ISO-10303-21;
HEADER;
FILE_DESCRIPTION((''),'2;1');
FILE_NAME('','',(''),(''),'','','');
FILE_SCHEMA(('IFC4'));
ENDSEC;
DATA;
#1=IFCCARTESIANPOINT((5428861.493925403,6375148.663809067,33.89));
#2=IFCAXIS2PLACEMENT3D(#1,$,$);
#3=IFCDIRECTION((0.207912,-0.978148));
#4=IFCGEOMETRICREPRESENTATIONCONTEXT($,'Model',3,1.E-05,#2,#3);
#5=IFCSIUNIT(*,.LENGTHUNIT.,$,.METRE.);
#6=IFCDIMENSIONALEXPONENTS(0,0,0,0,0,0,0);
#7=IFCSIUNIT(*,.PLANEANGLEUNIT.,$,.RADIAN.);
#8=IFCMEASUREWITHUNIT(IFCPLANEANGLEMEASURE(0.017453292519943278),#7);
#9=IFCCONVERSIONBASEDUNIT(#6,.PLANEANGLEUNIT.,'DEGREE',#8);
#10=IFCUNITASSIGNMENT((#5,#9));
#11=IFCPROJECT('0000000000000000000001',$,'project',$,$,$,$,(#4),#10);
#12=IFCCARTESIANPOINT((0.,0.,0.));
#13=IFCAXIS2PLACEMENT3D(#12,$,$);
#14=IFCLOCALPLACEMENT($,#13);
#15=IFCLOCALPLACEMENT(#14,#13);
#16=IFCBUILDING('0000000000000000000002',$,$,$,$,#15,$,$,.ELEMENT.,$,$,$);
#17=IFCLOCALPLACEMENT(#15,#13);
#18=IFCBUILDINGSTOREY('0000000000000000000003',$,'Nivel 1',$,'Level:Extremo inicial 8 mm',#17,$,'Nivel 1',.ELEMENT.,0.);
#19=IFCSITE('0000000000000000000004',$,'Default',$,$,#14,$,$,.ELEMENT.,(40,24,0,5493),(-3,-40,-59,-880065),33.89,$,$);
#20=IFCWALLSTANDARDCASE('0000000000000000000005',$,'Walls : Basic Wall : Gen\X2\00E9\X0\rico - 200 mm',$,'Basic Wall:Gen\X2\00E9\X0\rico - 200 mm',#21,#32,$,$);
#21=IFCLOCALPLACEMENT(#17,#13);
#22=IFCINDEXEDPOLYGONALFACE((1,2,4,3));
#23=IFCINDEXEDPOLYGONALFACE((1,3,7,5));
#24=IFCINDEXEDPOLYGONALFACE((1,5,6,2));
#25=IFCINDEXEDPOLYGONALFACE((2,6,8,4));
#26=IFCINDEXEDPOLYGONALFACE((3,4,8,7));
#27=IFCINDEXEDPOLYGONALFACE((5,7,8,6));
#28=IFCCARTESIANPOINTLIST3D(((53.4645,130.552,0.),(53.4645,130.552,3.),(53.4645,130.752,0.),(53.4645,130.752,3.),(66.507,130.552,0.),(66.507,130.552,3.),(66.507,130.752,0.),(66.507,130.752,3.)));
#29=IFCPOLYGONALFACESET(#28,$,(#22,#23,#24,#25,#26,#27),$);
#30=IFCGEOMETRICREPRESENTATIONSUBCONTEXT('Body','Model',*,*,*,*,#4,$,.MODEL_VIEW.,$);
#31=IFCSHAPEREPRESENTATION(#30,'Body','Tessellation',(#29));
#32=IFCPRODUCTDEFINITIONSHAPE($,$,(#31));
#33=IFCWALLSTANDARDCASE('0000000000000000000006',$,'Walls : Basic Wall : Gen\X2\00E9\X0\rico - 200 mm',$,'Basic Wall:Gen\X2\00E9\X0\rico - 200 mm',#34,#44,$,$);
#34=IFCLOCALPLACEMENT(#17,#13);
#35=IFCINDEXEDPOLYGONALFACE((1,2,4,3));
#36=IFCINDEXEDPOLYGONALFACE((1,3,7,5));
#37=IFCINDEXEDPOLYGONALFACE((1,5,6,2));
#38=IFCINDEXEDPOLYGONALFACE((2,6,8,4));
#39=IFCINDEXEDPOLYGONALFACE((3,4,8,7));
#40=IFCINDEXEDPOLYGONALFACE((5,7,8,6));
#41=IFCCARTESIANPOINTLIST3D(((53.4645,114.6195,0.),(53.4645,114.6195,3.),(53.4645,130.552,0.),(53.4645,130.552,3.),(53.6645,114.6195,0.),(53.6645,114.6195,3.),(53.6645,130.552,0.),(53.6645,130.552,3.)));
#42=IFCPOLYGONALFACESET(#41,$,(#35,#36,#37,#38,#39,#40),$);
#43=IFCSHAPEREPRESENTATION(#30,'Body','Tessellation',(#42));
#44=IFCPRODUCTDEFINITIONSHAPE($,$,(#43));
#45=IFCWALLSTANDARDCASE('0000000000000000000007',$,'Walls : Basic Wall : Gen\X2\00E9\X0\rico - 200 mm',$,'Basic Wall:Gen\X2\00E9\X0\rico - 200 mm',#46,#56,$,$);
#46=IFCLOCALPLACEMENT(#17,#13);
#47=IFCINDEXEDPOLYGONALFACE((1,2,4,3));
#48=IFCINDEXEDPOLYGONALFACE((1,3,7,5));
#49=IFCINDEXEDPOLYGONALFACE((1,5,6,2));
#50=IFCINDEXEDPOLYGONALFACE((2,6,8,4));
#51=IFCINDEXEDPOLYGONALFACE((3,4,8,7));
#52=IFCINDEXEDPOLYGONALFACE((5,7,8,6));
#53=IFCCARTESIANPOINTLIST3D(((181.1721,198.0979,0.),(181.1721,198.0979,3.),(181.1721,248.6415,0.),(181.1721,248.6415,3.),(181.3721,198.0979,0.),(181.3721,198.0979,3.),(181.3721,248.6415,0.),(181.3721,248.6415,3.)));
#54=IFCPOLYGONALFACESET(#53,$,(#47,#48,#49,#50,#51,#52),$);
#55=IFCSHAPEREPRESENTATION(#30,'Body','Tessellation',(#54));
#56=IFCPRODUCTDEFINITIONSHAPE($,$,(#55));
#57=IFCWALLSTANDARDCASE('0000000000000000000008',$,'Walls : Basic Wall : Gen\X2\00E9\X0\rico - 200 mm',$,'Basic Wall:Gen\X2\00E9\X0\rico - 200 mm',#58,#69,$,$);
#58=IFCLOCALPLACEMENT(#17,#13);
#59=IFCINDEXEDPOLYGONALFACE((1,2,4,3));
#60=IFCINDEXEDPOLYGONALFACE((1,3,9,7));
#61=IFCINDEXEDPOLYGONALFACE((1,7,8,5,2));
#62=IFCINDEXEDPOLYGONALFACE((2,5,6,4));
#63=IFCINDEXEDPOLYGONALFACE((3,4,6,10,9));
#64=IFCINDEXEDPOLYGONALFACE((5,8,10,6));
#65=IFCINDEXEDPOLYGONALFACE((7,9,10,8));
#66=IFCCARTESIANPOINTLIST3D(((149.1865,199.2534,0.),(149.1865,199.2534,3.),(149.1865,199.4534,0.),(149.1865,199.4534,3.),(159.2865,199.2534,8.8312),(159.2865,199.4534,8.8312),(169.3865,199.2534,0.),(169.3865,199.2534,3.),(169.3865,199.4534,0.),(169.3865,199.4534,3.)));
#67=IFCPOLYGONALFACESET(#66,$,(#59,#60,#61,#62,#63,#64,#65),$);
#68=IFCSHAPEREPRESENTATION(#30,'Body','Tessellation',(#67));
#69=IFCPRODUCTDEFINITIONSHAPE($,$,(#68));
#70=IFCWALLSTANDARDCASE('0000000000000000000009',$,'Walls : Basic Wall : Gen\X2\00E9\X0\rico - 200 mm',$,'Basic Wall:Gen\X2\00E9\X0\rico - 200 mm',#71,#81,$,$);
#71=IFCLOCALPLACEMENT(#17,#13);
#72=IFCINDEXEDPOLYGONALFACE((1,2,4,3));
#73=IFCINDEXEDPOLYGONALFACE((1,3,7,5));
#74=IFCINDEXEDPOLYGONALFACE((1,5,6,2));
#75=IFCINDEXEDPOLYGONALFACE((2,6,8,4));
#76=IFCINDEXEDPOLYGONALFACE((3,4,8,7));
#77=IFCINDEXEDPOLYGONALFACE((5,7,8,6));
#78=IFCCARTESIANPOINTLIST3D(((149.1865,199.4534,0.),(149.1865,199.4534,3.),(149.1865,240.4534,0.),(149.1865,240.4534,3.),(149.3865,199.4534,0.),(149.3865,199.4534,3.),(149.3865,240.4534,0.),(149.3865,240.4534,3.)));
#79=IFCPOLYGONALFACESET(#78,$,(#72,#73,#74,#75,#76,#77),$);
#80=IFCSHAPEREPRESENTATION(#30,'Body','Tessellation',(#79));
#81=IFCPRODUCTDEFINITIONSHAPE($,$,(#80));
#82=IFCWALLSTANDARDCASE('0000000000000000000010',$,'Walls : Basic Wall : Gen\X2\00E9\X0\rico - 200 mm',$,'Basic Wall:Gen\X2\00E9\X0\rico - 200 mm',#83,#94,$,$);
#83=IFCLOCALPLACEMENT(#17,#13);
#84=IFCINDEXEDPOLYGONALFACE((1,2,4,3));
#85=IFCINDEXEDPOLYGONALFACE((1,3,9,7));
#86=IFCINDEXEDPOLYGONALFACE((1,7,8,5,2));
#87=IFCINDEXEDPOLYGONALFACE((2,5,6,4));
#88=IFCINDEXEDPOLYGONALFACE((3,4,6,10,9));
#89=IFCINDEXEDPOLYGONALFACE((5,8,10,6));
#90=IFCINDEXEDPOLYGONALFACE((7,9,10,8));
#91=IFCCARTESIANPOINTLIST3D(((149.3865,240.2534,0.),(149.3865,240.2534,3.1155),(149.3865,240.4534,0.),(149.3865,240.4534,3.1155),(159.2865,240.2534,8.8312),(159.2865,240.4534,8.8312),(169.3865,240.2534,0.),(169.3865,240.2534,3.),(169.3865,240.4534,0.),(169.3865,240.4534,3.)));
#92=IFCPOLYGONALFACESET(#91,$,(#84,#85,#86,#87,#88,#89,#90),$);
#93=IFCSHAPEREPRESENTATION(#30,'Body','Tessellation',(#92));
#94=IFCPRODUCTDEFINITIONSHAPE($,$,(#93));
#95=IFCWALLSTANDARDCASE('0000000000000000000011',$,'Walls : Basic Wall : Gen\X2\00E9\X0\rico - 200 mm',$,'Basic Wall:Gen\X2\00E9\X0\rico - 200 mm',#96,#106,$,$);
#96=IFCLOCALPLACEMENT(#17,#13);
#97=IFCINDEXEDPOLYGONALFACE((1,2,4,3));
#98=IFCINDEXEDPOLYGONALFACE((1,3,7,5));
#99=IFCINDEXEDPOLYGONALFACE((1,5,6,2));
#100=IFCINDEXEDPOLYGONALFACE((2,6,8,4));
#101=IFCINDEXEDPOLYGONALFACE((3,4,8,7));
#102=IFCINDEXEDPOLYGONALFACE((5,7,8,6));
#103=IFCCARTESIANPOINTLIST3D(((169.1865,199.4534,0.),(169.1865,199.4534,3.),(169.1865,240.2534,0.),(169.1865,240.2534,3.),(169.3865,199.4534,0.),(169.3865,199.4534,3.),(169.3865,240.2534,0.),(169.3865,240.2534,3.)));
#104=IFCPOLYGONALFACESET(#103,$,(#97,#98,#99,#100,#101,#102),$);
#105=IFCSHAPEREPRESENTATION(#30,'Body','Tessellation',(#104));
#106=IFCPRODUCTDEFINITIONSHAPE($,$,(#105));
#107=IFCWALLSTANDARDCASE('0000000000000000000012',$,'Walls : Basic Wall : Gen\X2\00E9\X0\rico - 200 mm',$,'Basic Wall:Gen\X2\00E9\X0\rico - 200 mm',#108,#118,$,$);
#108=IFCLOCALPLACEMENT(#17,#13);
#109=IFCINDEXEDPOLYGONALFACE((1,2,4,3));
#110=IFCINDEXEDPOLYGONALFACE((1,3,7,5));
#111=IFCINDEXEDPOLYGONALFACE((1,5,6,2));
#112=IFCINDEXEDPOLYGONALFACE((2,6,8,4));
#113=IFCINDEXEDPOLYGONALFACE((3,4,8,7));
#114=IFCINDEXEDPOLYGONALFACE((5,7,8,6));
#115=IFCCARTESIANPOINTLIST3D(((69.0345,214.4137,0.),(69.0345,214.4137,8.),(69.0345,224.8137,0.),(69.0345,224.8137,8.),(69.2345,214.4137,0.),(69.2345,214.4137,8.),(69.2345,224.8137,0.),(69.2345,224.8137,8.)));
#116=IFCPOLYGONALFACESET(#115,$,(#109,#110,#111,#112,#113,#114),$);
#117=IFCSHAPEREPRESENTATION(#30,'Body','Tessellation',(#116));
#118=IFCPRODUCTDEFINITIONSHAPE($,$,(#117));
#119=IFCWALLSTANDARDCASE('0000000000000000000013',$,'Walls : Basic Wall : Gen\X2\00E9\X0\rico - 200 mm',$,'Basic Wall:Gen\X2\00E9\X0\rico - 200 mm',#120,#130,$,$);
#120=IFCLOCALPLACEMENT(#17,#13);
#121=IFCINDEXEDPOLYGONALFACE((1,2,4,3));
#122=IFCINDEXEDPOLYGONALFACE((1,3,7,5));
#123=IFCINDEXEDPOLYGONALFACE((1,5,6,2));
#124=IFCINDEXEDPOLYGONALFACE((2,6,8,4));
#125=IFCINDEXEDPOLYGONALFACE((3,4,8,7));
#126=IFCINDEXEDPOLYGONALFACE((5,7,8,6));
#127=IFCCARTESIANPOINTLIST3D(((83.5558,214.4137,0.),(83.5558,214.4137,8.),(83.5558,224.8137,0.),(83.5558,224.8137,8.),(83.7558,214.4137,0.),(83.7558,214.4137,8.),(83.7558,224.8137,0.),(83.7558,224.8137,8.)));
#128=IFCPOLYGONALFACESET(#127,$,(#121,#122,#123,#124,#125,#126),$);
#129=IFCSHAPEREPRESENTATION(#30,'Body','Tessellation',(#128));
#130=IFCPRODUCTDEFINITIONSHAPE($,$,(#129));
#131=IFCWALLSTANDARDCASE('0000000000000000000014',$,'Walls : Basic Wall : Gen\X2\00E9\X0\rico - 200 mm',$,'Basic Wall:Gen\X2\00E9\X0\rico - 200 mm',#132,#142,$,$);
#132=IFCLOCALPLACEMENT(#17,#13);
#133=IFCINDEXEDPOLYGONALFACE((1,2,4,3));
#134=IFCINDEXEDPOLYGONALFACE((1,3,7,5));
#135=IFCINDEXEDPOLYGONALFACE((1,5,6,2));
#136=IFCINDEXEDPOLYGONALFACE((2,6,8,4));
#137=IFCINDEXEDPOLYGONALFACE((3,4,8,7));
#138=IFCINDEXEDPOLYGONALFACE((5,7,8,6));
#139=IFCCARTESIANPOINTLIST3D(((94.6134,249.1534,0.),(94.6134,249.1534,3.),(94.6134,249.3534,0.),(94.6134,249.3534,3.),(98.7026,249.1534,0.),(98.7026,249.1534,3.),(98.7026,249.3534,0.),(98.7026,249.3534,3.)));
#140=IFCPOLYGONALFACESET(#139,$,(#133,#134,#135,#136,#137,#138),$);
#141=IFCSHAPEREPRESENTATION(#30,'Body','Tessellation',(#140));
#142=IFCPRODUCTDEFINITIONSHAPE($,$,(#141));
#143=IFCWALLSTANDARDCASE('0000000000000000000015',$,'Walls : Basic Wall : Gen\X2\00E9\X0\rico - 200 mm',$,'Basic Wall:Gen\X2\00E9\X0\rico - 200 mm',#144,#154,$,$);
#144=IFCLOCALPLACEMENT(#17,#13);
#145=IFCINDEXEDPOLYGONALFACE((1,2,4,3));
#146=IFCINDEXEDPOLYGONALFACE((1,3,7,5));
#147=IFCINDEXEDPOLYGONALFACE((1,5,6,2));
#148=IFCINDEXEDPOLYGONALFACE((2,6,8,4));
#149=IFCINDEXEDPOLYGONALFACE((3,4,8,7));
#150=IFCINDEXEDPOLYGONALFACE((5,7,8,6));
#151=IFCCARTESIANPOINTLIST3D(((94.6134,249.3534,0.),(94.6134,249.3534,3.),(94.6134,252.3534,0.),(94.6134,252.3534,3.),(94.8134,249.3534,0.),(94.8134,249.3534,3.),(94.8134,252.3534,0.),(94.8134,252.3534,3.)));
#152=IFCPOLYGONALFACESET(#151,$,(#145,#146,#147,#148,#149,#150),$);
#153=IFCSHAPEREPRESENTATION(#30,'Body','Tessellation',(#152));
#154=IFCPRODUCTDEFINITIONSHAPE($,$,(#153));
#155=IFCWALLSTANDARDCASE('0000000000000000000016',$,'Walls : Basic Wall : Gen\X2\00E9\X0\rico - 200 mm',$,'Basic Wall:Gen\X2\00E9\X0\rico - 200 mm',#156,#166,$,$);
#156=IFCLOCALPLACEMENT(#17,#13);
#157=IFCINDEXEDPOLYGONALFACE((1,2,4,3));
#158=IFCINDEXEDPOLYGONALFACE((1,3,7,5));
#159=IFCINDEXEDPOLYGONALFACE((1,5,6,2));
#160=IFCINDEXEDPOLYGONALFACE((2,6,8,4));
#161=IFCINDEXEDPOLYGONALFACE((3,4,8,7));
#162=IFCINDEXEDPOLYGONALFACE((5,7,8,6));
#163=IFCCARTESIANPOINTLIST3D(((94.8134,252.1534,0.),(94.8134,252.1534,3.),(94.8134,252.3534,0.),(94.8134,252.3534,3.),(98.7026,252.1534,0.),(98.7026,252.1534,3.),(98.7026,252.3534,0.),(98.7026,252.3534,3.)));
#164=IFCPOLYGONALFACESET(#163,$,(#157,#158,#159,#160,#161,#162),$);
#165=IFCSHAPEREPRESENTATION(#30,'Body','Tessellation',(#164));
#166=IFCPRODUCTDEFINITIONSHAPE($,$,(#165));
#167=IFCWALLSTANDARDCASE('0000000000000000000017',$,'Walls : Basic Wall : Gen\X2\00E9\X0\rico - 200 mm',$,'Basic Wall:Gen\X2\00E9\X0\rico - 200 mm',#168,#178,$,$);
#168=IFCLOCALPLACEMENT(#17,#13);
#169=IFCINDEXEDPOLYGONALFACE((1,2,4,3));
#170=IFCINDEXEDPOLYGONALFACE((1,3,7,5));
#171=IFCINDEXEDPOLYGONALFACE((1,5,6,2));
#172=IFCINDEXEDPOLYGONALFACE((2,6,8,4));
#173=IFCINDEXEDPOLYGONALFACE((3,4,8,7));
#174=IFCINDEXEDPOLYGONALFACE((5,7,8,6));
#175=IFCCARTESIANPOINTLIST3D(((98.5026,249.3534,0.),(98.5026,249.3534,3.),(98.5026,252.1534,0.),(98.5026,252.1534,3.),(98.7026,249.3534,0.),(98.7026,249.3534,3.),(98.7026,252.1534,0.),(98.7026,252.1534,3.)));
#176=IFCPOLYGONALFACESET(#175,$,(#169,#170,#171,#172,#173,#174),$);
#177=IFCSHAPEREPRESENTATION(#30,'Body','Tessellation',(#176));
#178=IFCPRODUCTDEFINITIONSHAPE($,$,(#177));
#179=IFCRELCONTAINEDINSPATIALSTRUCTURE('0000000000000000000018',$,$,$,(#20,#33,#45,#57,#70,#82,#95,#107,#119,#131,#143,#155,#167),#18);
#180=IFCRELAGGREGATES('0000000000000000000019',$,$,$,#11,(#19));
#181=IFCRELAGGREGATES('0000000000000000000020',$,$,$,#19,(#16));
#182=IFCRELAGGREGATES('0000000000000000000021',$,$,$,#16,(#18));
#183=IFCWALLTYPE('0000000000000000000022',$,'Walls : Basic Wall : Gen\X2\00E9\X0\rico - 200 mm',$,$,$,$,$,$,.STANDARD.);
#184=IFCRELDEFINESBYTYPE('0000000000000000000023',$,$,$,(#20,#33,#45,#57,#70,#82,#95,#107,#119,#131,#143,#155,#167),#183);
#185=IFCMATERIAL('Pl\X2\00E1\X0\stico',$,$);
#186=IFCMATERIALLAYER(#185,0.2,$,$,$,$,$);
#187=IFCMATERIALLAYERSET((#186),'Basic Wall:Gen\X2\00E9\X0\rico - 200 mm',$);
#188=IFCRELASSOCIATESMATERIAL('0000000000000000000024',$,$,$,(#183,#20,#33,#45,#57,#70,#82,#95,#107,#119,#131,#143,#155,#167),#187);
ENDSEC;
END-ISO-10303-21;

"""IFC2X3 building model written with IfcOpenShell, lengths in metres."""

from ifc_helpers import new_model, entity, si_unit, converted_unit, direction, frame, frame_2d, origin, place, context, subcontext, project, spatial, polyline, rectangle, extrude, clip, bounded_halfspace, material, layer, layer_set, layer_usage, type_object, element, save


model = new_model("IFC2X3")

# Units and contexts
model_context = context("Model", 3, precision=1e-05, world=frame((5428861.493925403, 6375148.663809067, 33.89)), true_north=direction((0.207912, -0.978148)))
body_context = subcontext(model_context, "Body", "Model", "MODEL_VIEW")
ifc_project = project(units=[si_unit("LENGTHUNIT", "METRE"), converted_unit("PLANEANGLEUNIT", "DEGREE", entity("IfcPlaneAngleMeasure", 0.017453292519943278), si_unit("PLANEANGLEUNIT", "RADIAN"), dimensions=[0, 0, 0, 0, 0, 0, 0])], contexts=[model_context])

# Site, building, storey
site_placement = place(None, origin())
site = spatial("IfcSite", under=ifc_project, at=site_placement, Name="Default", CompositionType="ELEMENT", RefLatitude=(40, 24, 0, 5493), RefLongitude=(-3, -40, -59, -880065), RefElevation=33.89)
building_placement = place(site_placement, origin())
building = spatial("IfcBuilding", under=site, at=building_placement, CompositionType="ELEMENT")
storey_placement = place(building_placement, origin())
storey = spatial("IfcBuildingStorey", under=building, at=storey_placement, Name="Nivel 1", ObjectType="Level:Extremo inicial 8 mm", LongName="Nivel 1", CompositionType="ELEMENT", Elevation=0.0)

# Walls
ifc_material_1 = material(Name="Plástico")
ifc_layer_1 = layer(ifc_material_1, 0.2)
ifc_layer_set_1 = layer_set([ifc_layer_1], Name="Basic Wall:Genérico - 200 mm")
ifc_layer_usage_1 = layer_usage(ifc_layer_set_1, "AXIS2", "NEGATIVE", 0.1)
wall_type = type_object("IfcWallType", Name="Walls : Basic Wall : Genérico - 200 mm", PredefinedType="STANDARD", material=ifc_layer_set_1)
wall_1_placement = place(storey_placement, frame((66.507, 130.652, 0.0), z_axis=(0.0, 0.0, 1.0), x_axis=(-1.0, 0.0, 0.0)))
element("IfcWallStandardCase", 1, at=wall_1_placement, inside=storey, type_object=wall_type, material=ifc_layer_usage_1, Name="Walls : Basic Wall : Genérico - 200 mm", ObjectType="Basic Wall:Genérico - 200 mm", context=body_context, shape_type="SweptSolid", body=[
    extrude(rectangle(XDim=13.0425, YDim=0.2, at=frame_2d((6.5213, 0.0), x_axis=(-1.0, 0.0))), origin(), (0.0, 0.0, 1.0), 3.0),
])
ifc_layer_usage_2 = layer_usage(ifc_layer_set_1, "AXIS2", "NEGATIVE", 0.1)
wall_2_placement = place(storey_placement, frame((53.5645, 130.552, 0.0), z_axis=(0.0, 0.0, 1.0), x_axis=(0.0, -1.0, 0.0)))
element("IfcWallStandardCase", 2, at=wall_2_placement, inside=storey, type_object=wall_type, material=ifc_layer_usage_2, Name="Walls : Basic Wall : Genérico - 200 mm", ObjectType="Basic Wall:Genérico - 200 mm", context=body_context, shape_type="SweptSolid", body=[
    extrude(rectangle(XDim=15.9325, YDim=0.2, at=frame_2d((7.9663, 0.0), x_axis=(-1.0, 0.0))), origin(), (0.0, 0.0, 1.0), 3.0),
])
ifc_layer_usage_3 = layer_usage(ifc_layer_set_1, "AXIS2", "NEGATIVE", 0.1)
wall_3_placement = place(storey_placement, frame((181.2721, 198.0979, 0.0), z_axis=(0.0, 0.0, 1.0), x_axis=(0.0, 1.0, 0.0)))
element("IfcWallStandardCase", 3, at=wall_3_placement, inside=storey, type_object=wall_type, material=ifc_layer_usage_3, Name="Walls : Basic Wall : Genérico - 200 mm", ObjectType="Basic Wall:Genérico - 200 mm", context=body_context, shape_type="SweptSolid", body=[
    extrude(rectangle(XDim=50.5436, YDim=0.2, at=frame_2d((25.2718, 0.0), x_axis=(-1.0, 0.0))), origin(), (0.0, 0.0, 1.0), 3.0),
])
ifc_layer_usage_4 = layer_usage(ifc_layer_set_1, "AXIS2", "NEGATIVE", 0.1)
wall_4_placement = place(storey_placement, frame((169.3865, 199.3534, 0.0), z_axis=(0.0, 0.0, 1.0), x_axis=(-1.0, 0.0, 0.0)))
element("IfcWallStandardCase", 4, at=wall_4_placement, inside=storey, type_object=wall_type, material=ifc_layer_usage_4, Name="Walls : Basic Wall : Genérico - 200 mm", ObjectType="Basic Wall:Genérico - 200 mm", context=body_context, shape_type="Clipping", body=[
    clip(clip(extrude(rectangle(XDim=20.2, YDim=0.2, at=frame_2d((10.1, 0.0), x_axis=(-1.0, 0.0))), origin(), (0.0, 0.0, 1.0), 8.8312), bounded_halfspace(frame((10.1, -0.1, 8.8312), z_axis=(0.5, 0.0, 0.866025), x_axis=(0.0, 1.0, 0.0)), False, frame((10.1, -0.1, 8.8312)), polyline([(0.0, 0.0), (10.1, 0.0), (10.1, 0.2), (0.0, 0.2), (0.0, 0.0)]))), bounded_halfspace(frame((0.0, -0.1, 3.0), z_axis=(-0.5, 0.0, 0.866025), x_axis=(0.0, -1.0, 0.0)), False, frame((0.0, -0.1, 3.0)), polyline([(0.0, 0.0), (10.1, 0.0), (10.1, 0.2), (0.0, 0.2), (0.0, 0.0)]))),
])
ifc_layer_usage_5 = layer_usage(ifc_layer_set_1, "AXIS2", "NEGATIVE", 0.1)
wall_5_placement = place(storey_placement, frame((149.2865, 199.4534, 0.0), z_axis=(0.0, 0.0, 1.0), x_axis=(0.0, 1.0, 0.0)))
element("IfcWallStandardCase", 5, at=wall_5_placement, inside=storey, type_object=wall_type, material=ifc_layer_usage_5, Name="Walls : Basic Wall : Genérico - 200 mm", ObjectType="Basic Wall:Genérico - 200 mm", context=body_context, shape_type="SweptSolid", body=[
    extrude(rectangle(XDim=41.0, YDim=0.2, at=frame_2d((20.5, 0.0), x_axis=(-1.0, 0.0))), origin(), (0.0, 0.0, 1.0), 3.0),
])
ifc_layer_usage_6 = layer_usage(ifc_layer_set_1, "AXIS2", "POSITIVE", -0.1)
wall_6_placement = place(storey_placement, frame((149.3865, 240.3534, 0.0)))
element("IfcWallStandardCase", 6, at=wall_6_placement, inside=storey, type_object=wall_type, material=ifc_layer_usage_6, Name="Walls : Basic Wall : Genérico - 200 mm", ObjectType="Basic Wall:Genérico - 200 mm", context=body_context, shape_type="Clipping", body=[
    clip(clip(extrude(rectangle(XDim=20.0, YDim=0.2, at=frame_2d((10.0, 0.0), x_axis=(-1.0, 0.0))), origin(), (0.0, 0.0, 1.0), 8.8312), bounded_halfspace(frame((0.0, -0.1, 3.1155), z_axis=(-0.5, 0.0, 0.866025), x_axis=(0.0, -1.0, 0.0)), False, frame((0.0, -0.1, 3.1155)), polyline([(0.0, 0.0), (9.9, 0.0), (9.9, 0.2), (0.0, 0.2), (0.0, 0.0)]))), bounded_halfspace(frame((9.9, -0.1, 8.8312), z_axis=(0.5, 0.0, 0.866025), x_axis=(0.0, 1.0, 0.0)), False, frame((9.9, -0.1, 8.8312)), polyline([(0.0, 0.0), (10.1, 0.0), (10.1, 0.2), (0.0, 0.2), (0.0, 0.0)]))),
])
ifc_layer_usage_7 = layer_usage(ifc_layer_set_1, "AXIS2", "NEGATIVE", 0.1)
wall_7_placement = place(storey_placement, frame((169.2865, 240.2534, 0.0), z_axis=(0.0, 0.0, 1.0), x_axis=(0.0, -1.0, 0.0)))
element("IfcWallStandardCase", 7, at=wall_7_placement, inside=storey, type_object=wall_type, material=ifc_layer_usage_7, Name="Walls : Basic Wall : Genérico - 200 mm", ObjectType="Basic Wall:Genérico - 200 mm", context=body_context, shape_type="SweptSolid", body=[
    extrude(rectangle(XDim=40.8, YDim=0.2, at=frame_2d((20.4, 0.0), x_axis=(-1.0, 0.0))), origin(), (0.0, 0.0, 1.0), 3.0),
])
ifc_layer_usage_8 = layer_usage(ifc_layer_set_1, "AXIS2", "NEGATIVE", 0.1)
wall_8_placement = place(storey_placement, frame((69.1345, 214.4137, 0.0), z_axis=(0.0, 0.0, 1.0), x_axis=(0.0, 1.0, 0.0)))
element("IfcWallStandardCase", 8, at=wall_8_placement, inside=storey, type_object=wall_type, material=ifc_layer_usage_8, Name="Walls : Basic Wall : Genérico - 200 mm", ObjectType="Basic Wall:Genérico - 200 mm", context=body_context, shape_type="SweptSolid", body=[
    extrude(rectangle(XDim=10.4, YDim=0.2, at=frame_2d((5.2, 0.0), x_axis=(-1.0, 0.0))), origin(), (0.0, 0.0, 1.0), 8.0),
])
ifc_layer_usage_9 = layer_usage(ifc_layer_set_1, "AXIS2", "NEGATIVE", 0.1)
wall_9_placement = place(storey_placement, frame((83.6558, 214.4137, 0.0), z_axis=(0.0, 0.0, 1.0), x_axis=(0.0, 1.0, 0.0)))
element("IfcWallStandardCase", 9, at=wall_9_placement, inside=storey, type_object=wall_type, material=ifc_layer_usage_9, Name="Walls : Basic Wall : Genérico - 200 mm", ObjectType="Basic Wall:Genérico - 200 mm", context=body_context, shape_type="SweptSolid", body=[
    extrude(rectangle(XDim=10.4, YDim=0.2, at=frame_2d((5.2, 0.0), x_axis=(-1.0, 0.0))), origin(), (0.0, 0.0, 1.0), 8.0),
])
ifc_layer_usage_10 = layer_usage(ifc_layer_set_1, "AXIS2", "NEGATIVE", 0.1)
wall_10_placement = place(storey_placement, frame((98.7026, 249.2534, 0.0), z_axis=(0.0, 0.0, 1.0), x_axis=(-1.0, 0.0, 0.0)))
element("IfcWallStandardCase", 10, at=wall_10_placement, inside=storey, type_object=wall_type, material=ifc_layer_usage_10, Name="Walls : Basic Wall : Genérico - 200 mm", ObjectType="Basic Wall:Genérico - 200 mm", context=body_context, shape_type="SweptSolid", body=[
    extrude(rectangle(XDim=4.0892, YDim=0.2, at=frame_2d((2.0446, 0.0), x_axis=(-1.0, 0.0))), origin(), (0.0, 0.0, 1.0), 3.0),
])
ifc_layer_usage_11 = layer_usage(ifc_layer_set_1, "AXIS2", "POSITIVE", -0.1)
wall_11_placement = place(storey_placement, frame((94.7134, 249.3534, 0.0), z_axis=(0.0, 0.0, 1.0), x_axis=(0.0, 1.0, 0.0)))
element("IfcWallStandardCase", 11, at=wall_11_placement, inside=storey, type_object=wall_type, material=ifc_layer_usage_11, Name="Walls : Basic Wall : Genérico - 200 mm", ObjectType="Basic Wall:Genérico - 200 mm", context=body_context, shape_type="SweptSolid", body=[
    extrude(rectangle(XDim=3.0, YDim=0.2, at=frame_2d((1.5, 0.0), x_axis=(-1.0, 0.0))), origin(), (0.0, 0.0, 1.0), 3.0),
])
ifc_layer_usage_12 = layer_usage(ifc_layer_set_1, "AXIS2", "NEGATIVE", 0.1)
wall_12_placement = place(storey_placement, frame((94.8134, 252.2534, 0.0)))
element("IfcWallStandardCase", 12, at=wall_12_placement, inside=storey, type_object=wall_type, material=ifc_layer_usage_12, Name="Walls : Basic Wall : Genérico - 200 mm", ObjectType="Basic Wall:Genérico - 200 mm", context=body_context, shape_type="SweptSolid", body=[
    extrude(rectangle(XDim=3.8892, YDim=0.2, at=frame_2d((1.9446, 0.0), x_axis=(-1.0, 0.0))), origin(), (0.0, 0.0, 1.0), 3.0),
])
ifc_layer_usage_13 = layer_usage(ifc_layer_set_1, "AXIS2", "NEGATIVE", 0.1)
wall_13_placement = place(storey_placement, frame((98.6026, 252.1534, 0.0), z_axis=(0.0, 0.0, 1.0), x_axis=(0.0, -1.0, 0.0)))
element("IfcWallStandardCase", 13, at=wall_13_placement, inside=storey, type_object=wall_type, material=ifc_layer_usage_13, Name="Walls : Basic Wall : Genérico - 200 mm", ObjectType="Basic Wall:Genérico - 200 mm", context=body_context, shape_type="SweptSolid", body=[
    extrude(rectangle(XDim=2.8, YDim=0.2, at=frame_2d((1.4, 0.0), x_axis=(-1.0, 0.0))), origin(), (0.0, 0.0, 1.0), 3.0),
])

save(model, "model.ifc")
